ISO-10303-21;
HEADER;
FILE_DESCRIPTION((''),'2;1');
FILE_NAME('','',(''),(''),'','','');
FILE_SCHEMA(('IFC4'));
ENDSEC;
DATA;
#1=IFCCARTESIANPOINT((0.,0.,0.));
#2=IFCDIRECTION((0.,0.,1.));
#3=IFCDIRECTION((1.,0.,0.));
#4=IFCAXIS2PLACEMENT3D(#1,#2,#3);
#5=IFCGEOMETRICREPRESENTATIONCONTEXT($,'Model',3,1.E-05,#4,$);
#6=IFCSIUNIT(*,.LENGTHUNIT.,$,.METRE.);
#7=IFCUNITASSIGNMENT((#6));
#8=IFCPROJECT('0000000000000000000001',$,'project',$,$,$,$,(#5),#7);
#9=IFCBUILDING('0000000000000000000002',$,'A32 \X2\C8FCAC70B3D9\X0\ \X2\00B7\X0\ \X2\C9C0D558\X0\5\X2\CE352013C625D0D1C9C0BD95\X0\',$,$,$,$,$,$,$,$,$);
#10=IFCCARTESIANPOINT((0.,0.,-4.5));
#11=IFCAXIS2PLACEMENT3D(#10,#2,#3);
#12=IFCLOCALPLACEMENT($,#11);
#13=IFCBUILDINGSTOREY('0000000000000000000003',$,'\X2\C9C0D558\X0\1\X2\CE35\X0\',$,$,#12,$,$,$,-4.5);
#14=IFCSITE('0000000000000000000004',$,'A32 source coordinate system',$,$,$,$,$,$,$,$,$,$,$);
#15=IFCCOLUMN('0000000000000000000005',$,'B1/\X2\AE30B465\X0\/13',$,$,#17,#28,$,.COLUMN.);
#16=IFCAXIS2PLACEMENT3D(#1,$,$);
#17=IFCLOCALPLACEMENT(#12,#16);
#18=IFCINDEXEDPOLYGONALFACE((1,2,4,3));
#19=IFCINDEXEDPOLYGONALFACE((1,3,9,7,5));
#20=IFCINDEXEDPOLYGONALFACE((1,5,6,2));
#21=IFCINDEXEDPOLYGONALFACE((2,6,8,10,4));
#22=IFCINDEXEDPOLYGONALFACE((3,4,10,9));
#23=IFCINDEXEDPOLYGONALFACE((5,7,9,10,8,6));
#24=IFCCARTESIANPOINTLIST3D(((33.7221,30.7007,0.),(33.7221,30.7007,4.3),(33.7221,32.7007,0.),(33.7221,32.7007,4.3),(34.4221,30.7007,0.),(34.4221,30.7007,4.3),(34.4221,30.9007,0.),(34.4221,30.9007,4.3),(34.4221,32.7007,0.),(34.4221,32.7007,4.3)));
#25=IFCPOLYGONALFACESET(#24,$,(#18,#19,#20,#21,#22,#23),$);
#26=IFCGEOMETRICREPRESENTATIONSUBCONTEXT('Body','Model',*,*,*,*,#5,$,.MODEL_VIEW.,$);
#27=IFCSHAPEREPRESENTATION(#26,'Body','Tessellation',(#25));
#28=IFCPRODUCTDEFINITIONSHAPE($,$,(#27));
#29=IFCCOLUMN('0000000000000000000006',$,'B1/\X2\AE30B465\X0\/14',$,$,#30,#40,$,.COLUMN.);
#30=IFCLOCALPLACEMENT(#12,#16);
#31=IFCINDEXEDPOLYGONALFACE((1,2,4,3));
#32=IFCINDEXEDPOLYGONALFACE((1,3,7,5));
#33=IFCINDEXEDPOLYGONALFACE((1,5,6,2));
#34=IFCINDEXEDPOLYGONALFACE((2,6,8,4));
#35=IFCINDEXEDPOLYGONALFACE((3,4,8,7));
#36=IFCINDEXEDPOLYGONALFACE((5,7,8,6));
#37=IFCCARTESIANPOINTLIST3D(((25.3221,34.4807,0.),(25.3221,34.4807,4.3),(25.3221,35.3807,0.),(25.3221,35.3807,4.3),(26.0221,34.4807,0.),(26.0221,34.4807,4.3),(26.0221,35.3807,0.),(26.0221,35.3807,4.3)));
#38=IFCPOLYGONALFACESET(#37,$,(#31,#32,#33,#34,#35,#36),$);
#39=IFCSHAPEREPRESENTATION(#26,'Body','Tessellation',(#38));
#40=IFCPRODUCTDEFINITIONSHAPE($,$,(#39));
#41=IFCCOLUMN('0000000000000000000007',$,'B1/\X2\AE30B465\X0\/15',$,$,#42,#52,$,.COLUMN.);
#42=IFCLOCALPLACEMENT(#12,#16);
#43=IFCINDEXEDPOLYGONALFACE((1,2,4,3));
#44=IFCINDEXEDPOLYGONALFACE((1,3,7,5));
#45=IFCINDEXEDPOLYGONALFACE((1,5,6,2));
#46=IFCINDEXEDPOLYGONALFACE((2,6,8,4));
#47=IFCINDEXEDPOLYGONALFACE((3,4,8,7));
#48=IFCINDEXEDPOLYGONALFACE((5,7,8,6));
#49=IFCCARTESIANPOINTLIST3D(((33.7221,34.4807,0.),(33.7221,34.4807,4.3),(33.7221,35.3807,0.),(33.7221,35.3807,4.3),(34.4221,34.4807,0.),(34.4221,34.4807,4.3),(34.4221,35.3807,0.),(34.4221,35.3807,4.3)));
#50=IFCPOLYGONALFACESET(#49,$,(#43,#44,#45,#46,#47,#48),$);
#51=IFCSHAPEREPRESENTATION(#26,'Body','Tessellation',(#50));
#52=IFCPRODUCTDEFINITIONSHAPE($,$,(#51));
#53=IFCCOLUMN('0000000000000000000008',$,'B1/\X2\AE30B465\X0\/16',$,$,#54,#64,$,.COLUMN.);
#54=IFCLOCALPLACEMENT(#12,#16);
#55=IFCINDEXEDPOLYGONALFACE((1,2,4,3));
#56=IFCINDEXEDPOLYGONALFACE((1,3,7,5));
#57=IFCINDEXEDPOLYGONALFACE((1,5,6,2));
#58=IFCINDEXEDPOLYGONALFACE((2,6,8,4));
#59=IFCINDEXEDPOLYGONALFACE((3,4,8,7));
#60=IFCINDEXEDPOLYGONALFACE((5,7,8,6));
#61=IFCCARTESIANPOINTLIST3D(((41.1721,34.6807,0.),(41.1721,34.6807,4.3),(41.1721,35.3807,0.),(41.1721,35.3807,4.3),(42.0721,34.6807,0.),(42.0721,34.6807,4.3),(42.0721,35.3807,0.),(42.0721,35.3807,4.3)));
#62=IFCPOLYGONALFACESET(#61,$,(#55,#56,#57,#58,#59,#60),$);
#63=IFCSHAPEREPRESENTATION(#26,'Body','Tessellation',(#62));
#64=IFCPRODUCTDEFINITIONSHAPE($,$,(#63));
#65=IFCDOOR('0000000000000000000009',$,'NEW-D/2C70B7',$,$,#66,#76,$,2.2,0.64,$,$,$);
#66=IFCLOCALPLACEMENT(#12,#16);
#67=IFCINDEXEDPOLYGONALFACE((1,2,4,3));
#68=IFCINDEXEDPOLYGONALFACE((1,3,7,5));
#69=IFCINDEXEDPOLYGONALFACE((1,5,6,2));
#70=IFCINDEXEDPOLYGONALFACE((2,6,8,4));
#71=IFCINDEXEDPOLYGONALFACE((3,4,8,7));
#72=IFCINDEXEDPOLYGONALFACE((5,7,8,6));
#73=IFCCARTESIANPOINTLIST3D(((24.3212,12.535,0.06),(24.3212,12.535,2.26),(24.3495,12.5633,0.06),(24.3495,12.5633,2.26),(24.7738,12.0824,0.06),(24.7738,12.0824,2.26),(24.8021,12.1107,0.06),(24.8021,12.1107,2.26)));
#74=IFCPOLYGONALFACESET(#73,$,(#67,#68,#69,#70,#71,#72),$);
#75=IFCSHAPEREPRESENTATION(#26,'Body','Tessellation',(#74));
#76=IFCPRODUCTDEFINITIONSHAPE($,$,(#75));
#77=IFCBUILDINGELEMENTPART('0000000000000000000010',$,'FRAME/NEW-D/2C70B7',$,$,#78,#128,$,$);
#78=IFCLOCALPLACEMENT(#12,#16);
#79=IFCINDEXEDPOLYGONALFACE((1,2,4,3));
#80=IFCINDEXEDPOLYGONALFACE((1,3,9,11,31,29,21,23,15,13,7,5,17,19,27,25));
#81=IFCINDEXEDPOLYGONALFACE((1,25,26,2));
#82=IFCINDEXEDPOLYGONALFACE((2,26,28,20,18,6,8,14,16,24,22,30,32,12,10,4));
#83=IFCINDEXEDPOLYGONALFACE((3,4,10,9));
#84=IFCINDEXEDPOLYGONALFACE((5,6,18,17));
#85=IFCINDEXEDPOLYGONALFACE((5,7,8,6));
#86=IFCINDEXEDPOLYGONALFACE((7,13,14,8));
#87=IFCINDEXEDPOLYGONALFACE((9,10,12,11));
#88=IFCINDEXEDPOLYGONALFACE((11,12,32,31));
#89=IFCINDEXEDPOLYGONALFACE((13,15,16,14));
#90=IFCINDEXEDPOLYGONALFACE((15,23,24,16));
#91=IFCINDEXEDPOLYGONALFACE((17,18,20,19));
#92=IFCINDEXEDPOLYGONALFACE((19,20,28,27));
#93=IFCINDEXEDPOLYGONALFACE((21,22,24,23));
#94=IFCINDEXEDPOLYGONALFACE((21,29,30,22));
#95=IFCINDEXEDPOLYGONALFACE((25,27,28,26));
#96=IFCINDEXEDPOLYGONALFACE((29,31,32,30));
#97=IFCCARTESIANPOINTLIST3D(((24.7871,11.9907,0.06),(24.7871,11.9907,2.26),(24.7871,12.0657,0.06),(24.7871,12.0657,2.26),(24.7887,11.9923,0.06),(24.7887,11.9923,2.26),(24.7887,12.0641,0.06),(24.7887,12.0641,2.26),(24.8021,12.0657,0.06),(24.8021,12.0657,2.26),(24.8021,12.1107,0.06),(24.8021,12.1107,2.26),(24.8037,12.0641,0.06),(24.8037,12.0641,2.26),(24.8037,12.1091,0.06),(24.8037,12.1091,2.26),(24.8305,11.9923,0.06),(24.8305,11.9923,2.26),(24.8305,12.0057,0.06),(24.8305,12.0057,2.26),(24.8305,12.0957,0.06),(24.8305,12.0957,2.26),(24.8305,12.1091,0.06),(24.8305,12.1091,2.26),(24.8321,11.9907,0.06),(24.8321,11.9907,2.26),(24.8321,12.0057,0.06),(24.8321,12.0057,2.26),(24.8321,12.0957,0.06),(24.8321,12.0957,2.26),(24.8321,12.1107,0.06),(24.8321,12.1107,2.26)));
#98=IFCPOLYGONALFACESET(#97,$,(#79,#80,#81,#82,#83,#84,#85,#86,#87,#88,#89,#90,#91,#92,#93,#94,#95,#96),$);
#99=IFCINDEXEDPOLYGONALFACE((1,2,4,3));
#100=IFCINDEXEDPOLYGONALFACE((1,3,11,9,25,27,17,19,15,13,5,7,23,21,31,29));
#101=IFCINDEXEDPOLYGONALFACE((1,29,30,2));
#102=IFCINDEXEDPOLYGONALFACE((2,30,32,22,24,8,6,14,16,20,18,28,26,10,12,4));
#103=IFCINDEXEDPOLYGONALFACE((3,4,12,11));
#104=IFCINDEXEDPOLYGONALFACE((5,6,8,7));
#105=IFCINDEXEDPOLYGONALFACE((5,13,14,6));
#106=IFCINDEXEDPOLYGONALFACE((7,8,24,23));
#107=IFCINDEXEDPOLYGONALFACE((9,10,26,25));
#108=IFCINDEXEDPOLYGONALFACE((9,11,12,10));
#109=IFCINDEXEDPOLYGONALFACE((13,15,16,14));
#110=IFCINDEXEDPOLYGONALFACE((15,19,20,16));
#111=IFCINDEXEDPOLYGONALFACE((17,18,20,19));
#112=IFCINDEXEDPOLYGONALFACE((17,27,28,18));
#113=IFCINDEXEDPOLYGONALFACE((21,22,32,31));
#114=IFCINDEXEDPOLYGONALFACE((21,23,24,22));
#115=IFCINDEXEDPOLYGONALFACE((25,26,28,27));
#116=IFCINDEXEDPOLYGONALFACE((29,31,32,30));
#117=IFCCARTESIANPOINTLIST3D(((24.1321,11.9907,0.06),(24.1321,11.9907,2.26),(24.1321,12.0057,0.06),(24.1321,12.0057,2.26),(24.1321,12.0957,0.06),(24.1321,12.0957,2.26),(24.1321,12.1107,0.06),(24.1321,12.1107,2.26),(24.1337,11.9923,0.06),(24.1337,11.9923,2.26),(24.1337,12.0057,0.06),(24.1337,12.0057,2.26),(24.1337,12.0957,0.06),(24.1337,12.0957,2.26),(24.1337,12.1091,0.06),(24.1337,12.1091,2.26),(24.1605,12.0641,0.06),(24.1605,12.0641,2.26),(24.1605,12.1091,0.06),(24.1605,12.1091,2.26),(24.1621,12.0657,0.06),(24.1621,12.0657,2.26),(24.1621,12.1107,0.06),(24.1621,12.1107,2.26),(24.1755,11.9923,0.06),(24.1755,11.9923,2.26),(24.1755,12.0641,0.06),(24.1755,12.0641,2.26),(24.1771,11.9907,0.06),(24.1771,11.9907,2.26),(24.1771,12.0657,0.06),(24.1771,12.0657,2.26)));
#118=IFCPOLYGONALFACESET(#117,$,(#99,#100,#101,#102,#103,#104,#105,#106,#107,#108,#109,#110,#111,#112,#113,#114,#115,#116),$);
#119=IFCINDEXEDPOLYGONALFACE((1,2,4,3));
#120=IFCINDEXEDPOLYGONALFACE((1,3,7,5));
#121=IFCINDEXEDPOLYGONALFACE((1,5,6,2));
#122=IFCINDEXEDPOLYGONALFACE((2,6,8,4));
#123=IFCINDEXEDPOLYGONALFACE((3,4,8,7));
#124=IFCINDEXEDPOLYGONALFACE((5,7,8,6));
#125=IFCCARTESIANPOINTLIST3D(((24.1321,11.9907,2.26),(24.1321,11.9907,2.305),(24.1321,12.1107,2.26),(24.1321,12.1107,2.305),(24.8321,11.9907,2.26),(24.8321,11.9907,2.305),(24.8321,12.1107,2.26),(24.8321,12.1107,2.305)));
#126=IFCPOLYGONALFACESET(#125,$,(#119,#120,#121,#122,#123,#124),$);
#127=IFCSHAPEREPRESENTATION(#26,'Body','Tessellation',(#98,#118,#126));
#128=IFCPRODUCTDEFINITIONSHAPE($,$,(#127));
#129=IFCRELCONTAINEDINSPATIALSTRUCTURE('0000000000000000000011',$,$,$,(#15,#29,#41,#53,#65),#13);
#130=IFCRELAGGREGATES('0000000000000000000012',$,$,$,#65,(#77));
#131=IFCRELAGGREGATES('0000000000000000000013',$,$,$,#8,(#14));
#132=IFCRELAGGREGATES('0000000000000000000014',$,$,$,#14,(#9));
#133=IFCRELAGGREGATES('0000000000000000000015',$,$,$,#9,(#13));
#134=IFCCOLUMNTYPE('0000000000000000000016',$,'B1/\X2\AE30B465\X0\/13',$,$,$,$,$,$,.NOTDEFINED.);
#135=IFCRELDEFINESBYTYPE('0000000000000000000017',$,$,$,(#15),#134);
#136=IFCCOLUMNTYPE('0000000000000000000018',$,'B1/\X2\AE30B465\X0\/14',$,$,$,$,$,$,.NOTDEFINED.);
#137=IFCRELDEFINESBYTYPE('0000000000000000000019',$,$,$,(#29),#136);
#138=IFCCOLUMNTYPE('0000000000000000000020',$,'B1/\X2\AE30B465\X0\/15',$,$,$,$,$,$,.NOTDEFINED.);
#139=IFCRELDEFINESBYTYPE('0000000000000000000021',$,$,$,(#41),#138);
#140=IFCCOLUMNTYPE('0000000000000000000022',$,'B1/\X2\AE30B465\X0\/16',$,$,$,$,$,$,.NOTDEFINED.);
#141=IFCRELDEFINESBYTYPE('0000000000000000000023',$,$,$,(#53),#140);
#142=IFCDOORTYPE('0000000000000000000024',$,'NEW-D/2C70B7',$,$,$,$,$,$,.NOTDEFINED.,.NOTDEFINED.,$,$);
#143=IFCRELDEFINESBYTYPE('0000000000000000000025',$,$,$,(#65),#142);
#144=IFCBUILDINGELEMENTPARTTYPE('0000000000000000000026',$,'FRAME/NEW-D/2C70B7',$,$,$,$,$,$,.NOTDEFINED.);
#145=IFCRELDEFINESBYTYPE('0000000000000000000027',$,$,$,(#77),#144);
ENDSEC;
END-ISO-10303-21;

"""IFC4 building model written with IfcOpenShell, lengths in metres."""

from ifc_helpers import new_model, si_unit, frame, origin, origin_with_axes, place, context, subcontext, project, spatial, polyline, outline, extrude, source, transform, mapped, type_object, type_shapes, element, aggregate, save


model = new_model("IFC4")

# Units and contexts
model_context = context("Model", 3, precision=1e-05, world=origin_with_axes())
body_context = subcontext(model_context, "Body", "Model", "MODEL_VIEW")
ifc_project = project(units=[si_unit("LENGTHUNIT", "METRE")], contexts=[model_context])

# Site, building, storey
site = spatial("IfcSite", under=ifc_project, Name="A32 source coordinate system")
building = spatial("IfcBuilding", under=site, Name="A32 주거동 · 지하5층–옥탑지붕")
storey_placement = place(None, frame((0.0, 0.0, -4.5), z_axis=(0.0, 0.0, 1.0), x_axis=(1.0, 0.0, 0.0)))
storey = spatial("IfcBuildingStorey", under=building, at=storey_placement, Name="지하1층", Elevation=-4.5)

# Columns
column_type_1 = type_object("IfcColumnType", Name="B1/기둥/13", PredefinedType="NOTDEFINED")
shared_shape_1 = source(origin(), body_context, "Body", "SweptSolid", [
    extrude(outline(polyline([(33.7221, 32.7007), (34.4221, 32.7007), (34.4221, 30.9007), (34.4221, 30.7007), (33.7221, 30.7007), (33.7221, 32.7007)])), origin(), (0.0, 0.0, 1.0), 4.3),
])
type_shapes(column_type_1, [shared_shape_1])
column_1_placement = place(storey_placement, origin_with_axes())
element("IfcColumn", 1, at=column_1_placement, inside=storey, type_object=column_type_1, Name="B1/기둥/13", PredefinedType="COLUMN", context=body_context, shape_type="MappedRepresentation", body=[
    mapped(shared_shape_1, transform((0.0, 0.0, 0.0), scale=1.0)),
])
column_type_2 = type_object("IfcColumnType", Name="B1/기둥/14", PredefinedType="NOTDEFINED")
shared_shape_2 = source(origin(), body_context, "Body", "SweptSolid", [
    extrude(outline(polyline([(26.0221, 34.4807), (25.3221, 34.4807), (25.3221, 35.3807), (26.0221, 35.3807), (26.0221, 34.4807)])), origin(), (0.0, 0.0, 1.0), 4.3),
])
type_shapes(column_type_2, [shared_shape_2])
column_2_placement = place(storey_placement, origin_with_axes())
element("IfcColumn", 2, at=column_2_placement, inside=storey, type_object=column_type_2, Name="B1/기둥/14", PredefinedType="COLUMN", context=body_context, shape_type="MappedRepresentation", body=[
    mapped(shared_shape_2, transform((0.0, 0.0, 0.0), scale=1.0)),
])
column_type_3 = type_object("IfcColumnType", Name="B1/기둥/15", PredefinedType="NOTDEFINED")
shared_shape_3 = source(origin(), body_context, "Body", "SweptSolid", [
    extrude(outline(polyline([(34.4221, 34.4807), (33.7221, 34.4807), (33.7221, 35.3807), (34.4221, 35.3807), (34.4221, 34.4807)])), origin(), (0.0, 0.0, 1.0), 4.3),
])
type_shapes(column_type_3, [shared_shape_3])
column_3_placement = place(storey_placement, origin_with_axes())
element("IfcColumn", 3, at=column_3_placement, inside=storey, type_object=column_type_3, Name="B1/기둥/15", PredefinedType="COLUMN", context=body_context, shape_type="MappedRepresentation", body=[
    mapped(shared_shape_3, transform((0.0, 0.0, 0.0), scale=1.0)),
])
column_type_4 = type_object("IfcColumnType", Name="B1/기둥/16", PredefinedType="NOTDEFINED")
shared_shape_4 = source(origin(), body_context, "Body", "SweptSolid", [
    extrude(outline(polyline([(42.0721, 35.3807), (42.0721, 34.6807), (41.1721, 34.6807), (41.1721, 35.3807), (42.0721, 35.3807)])), origin(), (0.0, 0.0, 1.0), 4.3),
])
type_shapes(column_type_4, [shared_shape_4])
column_4_placement = place(storey_placement, origin_with_axes())
element("IfcColumn", 4, at=column_4_placement, inside=storey, type_object=column_type_4, Name="B1/기둥/16", PredefinedType="COLUMN", context=body_context, shape_type="MappedRepresentation", body=[
    mapped(shared_shape_4, transform((0.0, 0.0, 0.0), scale=1.0)),
])

# Door
door_type_1 = type_object("IfcDoorType", Name="NEW-D/2C70B7", OperationType="NOTDEFINED", PredefinedType="NOTDEFINED")
shared_shape_5 = source(origin(), body_context, "Body", "SweptSolid", [
    extrude(outline(polyline([(24.8021, 12.1107), (24.7738, 12.0824), (24.3212, 12.535), (24.3495, 12.5633), (24.8021, 12.1107)])), frame((0.0, 0.0, 0.06)), (0.0, 0.0, 1.0), 2.2),
])
type_shapes(door_type_1, [shared_shape_5])
door_1_placement = place(storey_placement, origin_with_axes())
door_1 = element("IfcDoor", 5, at=door_1_placement, inside=storey, type_object=door_type_1, Name="NEW-D/2C70B7", OverallHeight=2.2, OverallWidth=0.64, context=body_context, shape_type="MappedRepresentation", body=[
    mapped(shared_shape_5, transform((0.0, 0.0, 0.0), scale=1.0)),
])

# Building element part
building_element_part_type_1 = type_object("IfcBuildingElementPartType", Name="FRAME/NEW-D/2C70B7", PredefinedType="NOTDEFINED")
shared_shape_6 = source(origin(), body_context, "Body", "SweptSolid", [
    extrude(outline(polyline([(24.8037, 12.1091), (24.8037, 12.0641), (24.7887, 12.0641), (24.7887, 11.9923), (24.8305, 11.9923), (24.8305, 12.0057), (24.8321, 12.0057), (24.8321, 11.9907), (24.7871, 11.9907), (24.7871, 12.0657), (24.8021, 12.0657), (24.8021, 12.1107), (24.8321, 12.1107), (24.8321, 12.0957), (24.8305, 12.0957), (24.8305, 12.1091), (24.8037, 12.1091)])), frame((0.0, 0.0, 0.06)), (0.0, 0.0, 1.0), 2.2),
    extrude(outline(polyline([(24.1321, 12.1107), (24.1621, 12.1107), (24.1621, 12.0657), (24.1771, 12.0657), (24.1771, 11.9907), (24.1321, 11.9907), (24.1321, 12.0057), (24.1337, 12.0057), (24.1337, 11.9923), (24.1755, 11.9923), (24.1755, 12.0641), (24.1605, 12.0641), (24.1605, 12.1091), (24.1337, 12.1091), (24.1337, 12.0957), (24.1321, 12.0957), (24.1321, 12.1107)])), frame((0.0, 0.0, 0.06)), (0.0, 0.0, 1.0), 2.2),
    extrude(outline(polyline([(24.8321, 11.9907), (24.8321, 12.1107), (24.1321, 12.1107), (24.1321, 11.9907), (24.8321, 11.9907)])), frame((0.0, 0.0, 2.26)), (0.0, 0.0, 1.0), 0.045),
])
type_shapes(building_element_part_type_1, [shared_shape_6])
building_element_part_1_placement = place(door_1_placement, origin_with_axes())
building_element_part_1 = element("IfcBuildingElementPart", 6, at=building_element_part_1_placement, type_object=building_element_part_type_1, Name="FRAME/NEW-D/2C70B7", context=body_context, shape_type="MappedRepresentation", body=[
    mapped(shared_shape_6, transform((0.0, 0.0, 0.0), scale=1.0)),
])
aggregate(door_1, [building_element_part_1])

save(model, "model.ifc")
